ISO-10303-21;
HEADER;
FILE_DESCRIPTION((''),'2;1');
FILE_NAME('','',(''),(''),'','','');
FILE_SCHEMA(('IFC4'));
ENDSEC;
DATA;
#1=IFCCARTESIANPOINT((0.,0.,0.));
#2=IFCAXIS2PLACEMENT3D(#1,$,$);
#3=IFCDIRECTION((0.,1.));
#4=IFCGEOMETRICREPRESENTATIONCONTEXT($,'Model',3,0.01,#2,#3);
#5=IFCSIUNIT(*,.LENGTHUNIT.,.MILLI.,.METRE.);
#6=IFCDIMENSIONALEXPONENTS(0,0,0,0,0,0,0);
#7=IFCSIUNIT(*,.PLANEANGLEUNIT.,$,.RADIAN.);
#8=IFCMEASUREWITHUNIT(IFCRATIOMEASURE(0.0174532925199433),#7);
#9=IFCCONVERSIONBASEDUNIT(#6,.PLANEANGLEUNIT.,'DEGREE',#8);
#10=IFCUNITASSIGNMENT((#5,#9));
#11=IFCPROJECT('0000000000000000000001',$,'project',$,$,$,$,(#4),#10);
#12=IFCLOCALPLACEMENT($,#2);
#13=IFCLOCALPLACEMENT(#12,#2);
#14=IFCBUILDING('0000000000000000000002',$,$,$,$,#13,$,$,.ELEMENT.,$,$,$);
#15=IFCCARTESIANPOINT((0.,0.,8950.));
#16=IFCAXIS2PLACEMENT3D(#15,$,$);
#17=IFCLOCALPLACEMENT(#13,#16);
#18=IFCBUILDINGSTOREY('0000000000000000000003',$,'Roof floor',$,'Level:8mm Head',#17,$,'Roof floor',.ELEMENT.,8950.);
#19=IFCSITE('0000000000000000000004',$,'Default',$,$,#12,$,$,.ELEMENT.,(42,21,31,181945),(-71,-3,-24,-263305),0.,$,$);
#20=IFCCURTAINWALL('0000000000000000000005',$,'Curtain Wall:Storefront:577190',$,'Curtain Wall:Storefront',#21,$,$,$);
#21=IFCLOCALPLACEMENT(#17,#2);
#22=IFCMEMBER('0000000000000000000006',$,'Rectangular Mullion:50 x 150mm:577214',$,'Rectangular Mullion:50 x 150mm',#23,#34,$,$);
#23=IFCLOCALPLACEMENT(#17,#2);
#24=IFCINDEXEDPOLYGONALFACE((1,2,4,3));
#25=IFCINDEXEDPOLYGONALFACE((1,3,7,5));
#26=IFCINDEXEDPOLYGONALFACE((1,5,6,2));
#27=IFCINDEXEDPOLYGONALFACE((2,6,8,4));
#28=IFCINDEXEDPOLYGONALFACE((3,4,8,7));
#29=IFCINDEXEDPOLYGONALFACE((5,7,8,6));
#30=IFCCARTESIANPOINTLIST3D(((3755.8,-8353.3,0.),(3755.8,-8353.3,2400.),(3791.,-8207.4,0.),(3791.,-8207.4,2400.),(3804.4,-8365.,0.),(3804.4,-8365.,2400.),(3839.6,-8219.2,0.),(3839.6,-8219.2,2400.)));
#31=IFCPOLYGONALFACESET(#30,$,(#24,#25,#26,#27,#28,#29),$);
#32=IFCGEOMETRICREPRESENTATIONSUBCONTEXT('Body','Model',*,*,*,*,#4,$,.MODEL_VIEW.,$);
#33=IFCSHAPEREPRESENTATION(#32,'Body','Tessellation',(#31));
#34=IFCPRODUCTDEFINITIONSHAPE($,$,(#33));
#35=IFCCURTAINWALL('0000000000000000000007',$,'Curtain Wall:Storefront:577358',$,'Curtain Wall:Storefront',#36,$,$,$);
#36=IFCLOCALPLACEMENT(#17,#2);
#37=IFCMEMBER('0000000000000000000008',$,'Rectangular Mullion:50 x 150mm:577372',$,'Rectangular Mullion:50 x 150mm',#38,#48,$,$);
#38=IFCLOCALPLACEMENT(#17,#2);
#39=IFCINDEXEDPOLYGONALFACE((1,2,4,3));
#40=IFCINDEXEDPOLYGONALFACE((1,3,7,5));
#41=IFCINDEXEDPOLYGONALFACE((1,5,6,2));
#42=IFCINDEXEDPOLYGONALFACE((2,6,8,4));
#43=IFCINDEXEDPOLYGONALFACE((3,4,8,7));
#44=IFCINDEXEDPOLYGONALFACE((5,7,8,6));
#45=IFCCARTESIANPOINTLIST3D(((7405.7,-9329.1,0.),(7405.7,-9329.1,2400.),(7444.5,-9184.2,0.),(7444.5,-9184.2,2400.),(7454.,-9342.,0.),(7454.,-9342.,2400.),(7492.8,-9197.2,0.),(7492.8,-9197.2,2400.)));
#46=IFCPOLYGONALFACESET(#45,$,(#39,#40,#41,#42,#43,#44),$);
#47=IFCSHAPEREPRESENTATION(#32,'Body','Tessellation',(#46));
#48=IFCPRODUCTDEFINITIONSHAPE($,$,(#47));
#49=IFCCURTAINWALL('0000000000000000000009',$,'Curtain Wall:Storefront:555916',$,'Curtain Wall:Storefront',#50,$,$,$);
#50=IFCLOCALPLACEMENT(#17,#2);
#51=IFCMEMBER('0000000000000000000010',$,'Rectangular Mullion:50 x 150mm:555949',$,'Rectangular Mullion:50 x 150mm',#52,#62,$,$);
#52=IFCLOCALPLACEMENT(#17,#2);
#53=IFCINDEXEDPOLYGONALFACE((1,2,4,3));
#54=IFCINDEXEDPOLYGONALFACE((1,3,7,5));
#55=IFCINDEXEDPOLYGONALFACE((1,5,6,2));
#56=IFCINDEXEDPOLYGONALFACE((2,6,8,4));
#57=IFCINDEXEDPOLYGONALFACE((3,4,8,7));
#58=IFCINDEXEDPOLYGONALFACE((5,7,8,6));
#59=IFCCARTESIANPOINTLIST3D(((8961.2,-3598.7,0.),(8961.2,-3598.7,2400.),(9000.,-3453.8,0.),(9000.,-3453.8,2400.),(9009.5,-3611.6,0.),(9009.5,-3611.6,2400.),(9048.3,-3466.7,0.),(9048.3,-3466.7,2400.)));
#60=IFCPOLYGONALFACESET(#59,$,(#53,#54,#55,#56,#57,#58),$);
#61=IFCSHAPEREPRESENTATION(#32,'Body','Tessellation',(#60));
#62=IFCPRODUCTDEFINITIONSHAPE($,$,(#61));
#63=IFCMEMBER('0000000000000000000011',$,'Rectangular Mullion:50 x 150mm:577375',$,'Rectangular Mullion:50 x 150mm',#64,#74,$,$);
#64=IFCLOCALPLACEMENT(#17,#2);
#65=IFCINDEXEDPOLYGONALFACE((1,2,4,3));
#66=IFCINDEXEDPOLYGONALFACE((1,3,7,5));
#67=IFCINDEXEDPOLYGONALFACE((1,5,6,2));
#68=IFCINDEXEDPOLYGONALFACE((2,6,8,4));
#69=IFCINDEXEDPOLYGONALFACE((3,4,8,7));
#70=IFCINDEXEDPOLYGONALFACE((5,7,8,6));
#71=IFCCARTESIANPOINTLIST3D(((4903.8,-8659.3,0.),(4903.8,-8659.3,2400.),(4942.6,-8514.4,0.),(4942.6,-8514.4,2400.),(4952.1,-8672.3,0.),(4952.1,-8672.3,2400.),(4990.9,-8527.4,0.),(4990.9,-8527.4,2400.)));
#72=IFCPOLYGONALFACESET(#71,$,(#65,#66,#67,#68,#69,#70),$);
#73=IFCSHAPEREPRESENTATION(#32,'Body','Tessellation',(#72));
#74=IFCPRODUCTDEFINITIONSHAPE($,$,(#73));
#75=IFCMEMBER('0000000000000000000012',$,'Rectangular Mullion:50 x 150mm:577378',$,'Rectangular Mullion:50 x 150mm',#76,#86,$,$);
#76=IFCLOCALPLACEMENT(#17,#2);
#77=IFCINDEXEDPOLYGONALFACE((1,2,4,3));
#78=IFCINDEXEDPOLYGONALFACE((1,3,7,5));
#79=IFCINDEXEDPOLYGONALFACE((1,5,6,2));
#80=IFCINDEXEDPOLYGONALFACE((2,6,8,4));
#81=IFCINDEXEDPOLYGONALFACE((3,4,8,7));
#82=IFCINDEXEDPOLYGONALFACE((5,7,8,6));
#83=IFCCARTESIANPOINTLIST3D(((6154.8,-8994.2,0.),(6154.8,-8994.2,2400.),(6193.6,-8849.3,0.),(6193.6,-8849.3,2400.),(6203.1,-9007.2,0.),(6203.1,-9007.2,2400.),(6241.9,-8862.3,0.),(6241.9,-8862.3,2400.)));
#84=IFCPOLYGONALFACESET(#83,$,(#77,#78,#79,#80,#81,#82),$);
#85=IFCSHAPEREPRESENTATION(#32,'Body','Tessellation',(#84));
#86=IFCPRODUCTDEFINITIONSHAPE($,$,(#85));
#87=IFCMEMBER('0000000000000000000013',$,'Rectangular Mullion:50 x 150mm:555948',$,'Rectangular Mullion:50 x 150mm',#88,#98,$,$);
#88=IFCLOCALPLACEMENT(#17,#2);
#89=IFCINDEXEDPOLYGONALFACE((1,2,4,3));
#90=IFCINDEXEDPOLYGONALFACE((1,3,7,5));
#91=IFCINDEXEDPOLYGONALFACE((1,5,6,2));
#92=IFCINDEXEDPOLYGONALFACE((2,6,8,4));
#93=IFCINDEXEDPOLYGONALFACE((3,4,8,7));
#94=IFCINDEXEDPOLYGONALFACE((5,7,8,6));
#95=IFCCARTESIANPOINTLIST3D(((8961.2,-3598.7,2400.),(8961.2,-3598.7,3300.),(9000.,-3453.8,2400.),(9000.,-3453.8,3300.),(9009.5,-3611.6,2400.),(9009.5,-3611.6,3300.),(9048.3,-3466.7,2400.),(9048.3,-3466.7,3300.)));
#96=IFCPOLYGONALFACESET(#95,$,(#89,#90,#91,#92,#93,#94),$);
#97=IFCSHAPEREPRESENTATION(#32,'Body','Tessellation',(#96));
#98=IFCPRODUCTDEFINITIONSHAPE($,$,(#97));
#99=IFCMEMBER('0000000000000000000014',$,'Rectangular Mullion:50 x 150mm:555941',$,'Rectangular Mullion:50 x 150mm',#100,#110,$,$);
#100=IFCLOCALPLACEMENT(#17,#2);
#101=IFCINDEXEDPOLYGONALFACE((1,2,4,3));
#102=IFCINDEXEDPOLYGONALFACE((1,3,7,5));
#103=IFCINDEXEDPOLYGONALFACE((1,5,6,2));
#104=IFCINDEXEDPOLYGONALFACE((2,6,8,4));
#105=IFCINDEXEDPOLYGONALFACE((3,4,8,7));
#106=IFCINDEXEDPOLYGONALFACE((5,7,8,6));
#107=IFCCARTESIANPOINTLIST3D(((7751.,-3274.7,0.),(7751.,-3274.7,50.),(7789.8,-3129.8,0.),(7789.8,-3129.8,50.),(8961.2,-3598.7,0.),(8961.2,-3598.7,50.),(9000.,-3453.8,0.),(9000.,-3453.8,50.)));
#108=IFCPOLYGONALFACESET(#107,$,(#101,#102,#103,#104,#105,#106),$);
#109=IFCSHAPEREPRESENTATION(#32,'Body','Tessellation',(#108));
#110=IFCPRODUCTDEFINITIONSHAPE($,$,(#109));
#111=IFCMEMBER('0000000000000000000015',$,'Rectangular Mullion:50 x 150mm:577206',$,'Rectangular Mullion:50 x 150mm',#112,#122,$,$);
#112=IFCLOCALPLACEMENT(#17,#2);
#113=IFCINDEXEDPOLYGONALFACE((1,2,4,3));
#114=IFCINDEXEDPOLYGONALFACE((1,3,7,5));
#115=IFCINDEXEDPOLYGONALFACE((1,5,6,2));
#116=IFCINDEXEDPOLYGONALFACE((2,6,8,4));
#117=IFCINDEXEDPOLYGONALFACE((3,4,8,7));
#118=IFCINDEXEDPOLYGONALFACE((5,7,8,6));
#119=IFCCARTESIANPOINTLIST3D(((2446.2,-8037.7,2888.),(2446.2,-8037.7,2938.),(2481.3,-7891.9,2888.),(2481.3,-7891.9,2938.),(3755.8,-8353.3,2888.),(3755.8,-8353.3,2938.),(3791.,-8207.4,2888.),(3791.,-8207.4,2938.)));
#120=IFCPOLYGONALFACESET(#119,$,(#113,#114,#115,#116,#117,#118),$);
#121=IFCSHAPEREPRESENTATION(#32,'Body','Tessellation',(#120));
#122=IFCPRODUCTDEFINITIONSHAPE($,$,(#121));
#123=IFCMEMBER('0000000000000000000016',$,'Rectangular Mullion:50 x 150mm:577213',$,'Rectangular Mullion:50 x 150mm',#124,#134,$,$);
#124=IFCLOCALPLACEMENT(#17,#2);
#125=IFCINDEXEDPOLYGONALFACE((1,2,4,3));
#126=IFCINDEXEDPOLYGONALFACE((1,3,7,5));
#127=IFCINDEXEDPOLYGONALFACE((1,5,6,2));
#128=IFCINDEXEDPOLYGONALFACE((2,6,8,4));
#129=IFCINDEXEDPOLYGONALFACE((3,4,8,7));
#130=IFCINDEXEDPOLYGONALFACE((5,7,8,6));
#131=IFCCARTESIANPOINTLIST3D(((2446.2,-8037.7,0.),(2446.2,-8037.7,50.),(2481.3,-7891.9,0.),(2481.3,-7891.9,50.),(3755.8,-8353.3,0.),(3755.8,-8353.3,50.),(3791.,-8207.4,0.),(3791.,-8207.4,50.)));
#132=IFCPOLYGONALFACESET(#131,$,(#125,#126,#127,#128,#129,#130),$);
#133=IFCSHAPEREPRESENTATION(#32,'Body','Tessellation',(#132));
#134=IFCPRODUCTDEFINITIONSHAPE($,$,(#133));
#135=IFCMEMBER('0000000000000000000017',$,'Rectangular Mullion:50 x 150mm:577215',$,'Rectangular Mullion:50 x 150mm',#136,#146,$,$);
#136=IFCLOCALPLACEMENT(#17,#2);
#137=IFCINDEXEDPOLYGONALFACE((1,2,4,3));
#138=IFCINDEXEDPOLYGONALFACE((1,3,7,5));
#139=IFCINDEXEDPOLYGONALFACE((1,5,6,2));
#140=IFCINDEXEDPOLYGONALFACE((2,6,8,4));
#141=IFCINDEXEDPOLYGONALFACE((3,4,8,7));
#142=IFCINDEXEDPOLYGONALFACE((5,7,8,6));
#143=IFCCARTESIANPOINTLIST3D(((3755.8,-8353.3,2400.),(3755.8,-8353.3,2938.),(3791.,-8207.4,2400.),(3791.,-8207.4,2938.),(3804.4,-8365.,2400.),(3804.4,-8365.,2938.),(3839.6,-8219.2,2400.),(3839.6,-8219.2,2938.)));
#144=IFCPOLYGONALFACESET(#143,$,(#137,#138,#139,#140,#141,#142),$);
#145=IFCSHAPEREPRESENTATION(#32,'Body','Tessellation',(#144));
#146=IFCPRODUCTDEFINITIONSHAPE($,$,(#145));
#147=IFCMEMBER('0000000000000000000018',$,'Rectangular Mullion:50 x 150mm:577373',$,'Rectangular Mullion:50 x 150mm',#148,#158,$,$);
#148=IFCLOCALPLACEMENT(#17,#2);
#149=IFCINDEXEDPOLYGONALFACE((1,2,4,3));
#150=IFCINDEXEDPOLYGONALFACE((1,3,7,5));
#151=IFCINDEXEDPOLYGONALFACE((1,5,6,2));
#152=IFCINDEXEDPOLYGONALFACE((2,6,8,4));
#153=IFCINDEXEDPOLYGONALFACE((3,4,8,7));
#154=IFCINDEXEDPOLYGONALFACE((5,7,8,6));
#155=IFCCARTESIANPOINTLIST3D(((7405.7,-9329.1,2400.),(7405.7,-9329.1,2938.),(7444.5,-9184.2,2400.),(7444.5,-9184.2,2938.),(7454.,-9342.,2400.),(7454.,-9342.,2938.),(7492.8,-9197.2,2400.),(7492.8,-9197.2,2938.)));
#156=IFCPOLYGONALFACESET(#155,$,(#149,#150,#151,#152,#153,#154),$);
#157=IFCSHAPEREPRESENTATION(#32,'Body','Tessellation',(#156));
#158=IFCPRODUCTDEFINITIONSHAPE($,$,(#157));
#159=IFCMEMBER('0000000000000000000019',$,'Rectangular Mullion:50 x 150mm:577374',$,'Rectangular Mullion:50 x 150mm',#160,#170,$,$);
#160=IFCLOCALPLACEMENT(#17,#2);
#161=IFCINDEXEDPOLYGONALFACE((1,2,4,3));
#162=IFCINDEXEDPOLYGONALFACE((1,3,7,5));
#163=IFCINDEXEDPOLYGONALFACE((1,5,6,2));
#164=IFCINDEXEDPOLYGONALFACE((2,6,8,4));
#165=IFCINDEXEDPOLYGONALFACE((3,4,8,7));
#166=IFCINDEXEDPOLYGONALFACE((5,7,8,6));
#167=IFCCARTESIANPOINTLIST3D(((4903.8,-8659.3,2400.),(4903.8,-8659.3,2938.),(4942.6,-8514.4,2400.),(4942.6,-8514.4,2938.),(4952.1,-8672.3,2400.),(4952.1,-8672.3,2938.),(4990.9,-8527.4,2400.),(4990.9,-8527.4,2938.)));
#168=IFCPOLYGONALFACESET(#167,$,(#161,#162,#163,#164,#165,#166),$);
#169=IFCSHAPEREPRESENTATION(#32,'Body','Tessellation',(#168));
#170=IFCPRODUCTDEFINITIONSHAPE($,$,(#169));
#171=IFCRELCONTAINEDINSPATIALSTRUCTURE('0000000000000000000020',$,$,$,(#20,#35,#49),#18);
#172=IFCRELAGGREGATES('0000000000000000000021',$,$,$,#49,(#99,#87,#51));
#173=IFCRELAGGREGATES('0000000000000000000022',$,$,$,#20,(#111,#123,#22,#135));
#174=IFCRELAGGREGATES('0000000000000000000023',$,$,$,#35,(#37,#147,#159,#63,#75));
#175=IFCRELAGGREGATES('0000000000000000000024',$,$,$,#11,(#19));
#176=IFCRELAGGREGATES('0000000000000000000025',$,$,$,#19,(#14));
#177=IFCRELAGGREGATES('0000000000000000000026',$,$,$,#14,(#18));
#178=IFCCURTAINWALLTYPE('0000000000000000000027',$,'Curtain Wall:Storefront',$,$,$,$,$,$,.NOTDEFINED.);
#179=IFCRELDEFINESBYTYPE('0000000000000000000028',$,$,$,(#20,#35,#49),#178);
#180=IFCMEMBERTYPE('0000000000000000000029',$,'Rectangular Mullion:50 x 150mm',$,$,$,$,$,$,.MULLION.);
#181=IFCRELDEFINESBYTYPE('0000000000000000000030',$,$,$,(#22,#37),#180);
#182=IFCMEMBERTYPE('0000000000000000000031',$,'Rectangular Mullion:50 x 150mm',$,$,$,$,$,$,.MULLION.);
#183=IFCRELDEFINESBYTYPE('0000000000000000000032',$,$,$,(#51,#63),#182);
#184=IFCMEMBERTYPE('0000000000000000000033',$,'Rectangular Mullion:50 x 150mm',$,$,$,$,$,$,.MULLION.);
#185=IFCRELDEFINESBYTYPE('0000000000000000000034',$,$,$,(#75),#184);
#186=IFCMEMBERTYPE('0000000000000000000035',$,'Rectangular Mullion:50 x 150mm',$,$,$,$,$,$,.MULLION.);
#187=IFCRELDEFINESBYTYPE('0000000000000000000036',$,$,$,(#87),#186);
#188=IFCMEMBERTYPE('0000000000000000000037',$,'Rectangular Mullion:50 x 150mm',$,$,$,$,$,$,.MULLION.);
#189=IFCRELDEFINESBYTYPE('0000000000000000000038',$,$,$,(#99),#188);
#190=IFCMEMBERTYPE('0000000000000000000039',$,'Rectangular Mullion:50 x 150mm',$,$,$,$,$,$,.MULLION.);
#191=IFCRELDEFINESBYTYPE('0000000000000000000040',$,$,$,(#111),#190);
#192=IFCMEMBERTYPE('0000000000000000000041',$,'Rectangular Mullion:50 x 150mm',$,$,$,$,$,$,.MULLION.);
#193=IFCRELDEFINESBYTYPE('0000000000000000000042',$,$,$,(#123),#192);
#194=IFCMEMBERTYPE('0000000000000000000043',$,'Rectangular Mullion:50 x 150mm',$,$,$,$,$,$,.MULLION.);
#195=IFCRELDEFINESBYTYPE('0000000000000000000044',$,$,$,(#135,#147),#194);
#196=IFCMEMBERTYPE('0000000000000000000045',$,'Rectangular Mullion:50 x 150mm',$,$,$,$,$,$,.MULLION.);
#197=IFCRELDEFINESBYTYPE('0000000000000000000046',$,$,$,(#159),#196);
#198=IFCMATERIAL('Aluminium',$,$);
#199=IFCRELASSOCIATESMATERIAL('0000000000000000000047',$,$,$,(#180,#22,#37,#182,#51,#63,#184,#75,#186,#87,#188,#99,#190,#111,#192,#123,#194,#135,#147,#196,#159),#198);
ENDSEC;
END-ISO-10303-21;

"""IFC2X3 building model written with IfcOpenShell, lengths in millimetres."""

from ifc_helpers import new_model, entity, si_unit, converted_unit, direction, frame, origin, origin_2d_with_axis, place, context, subcontext, project, spatial, rectangle, extrude, source, transform, mapped, material, type_object, type_shapes, element, aggregate, save


model = new_model("IFC2X3")

# Units and contexts
model_context = context("Model", 3, precision=0.01, world=origin(), true_north=direction((0.0, 1.0)))
body_context = subcontext(model_context, "Body", "Model", "MODEL_VIEW")
ifc_project = project(units=[si_unit("LENGTHUNIT", "METRE", prefix="MILLI"), converted_unit("PLANEANGLEUNIT", "DEGREE", entity("IfcRatioMeasure", 0.0174532925199433), si_unit("PLANEANGLEUNIT", "RADIAN"), dimensions=[0, 0, 0, 0, 0, 0, 0])], contexts=[model_context])

# Site, building, storey
site_placement = place(None, origin())
site = spatial("IfcSite", under=ifc_project, at=site_placement, Name="Default", CompositionType="ELEMENT", RefLatitude=(42, 21, 31, 181945), RefLongitude=(-71, -3, -24, -263305), RefElevation=0.0)
building_placement = place(site_placement, origin())
building = spatial("IfcBuilding", under=site, at=building_placement, CompositionType="ELEMENT")
storey_placement = place(building_placement, frame((0.0, 0.0, 8950.0)))
storey = spatial("IfcBuildingStorey", under=building, at=storey_placement, Name="Roof floor", ObjectType="Level:8mm Head", LongName="Roof floor", CompositionType="ELEMENT", Elevation=8950.0)

# Curtain walls, members
curtain_wall_type = type_object("IfcCurtainWallType", Name="Curtain Wall:Storefront", PredefinedType="NOTDEFINED")
curtain_wall_1_placement = place(storey_placement, frame((0.0, 0.0, -8950.0)))
curtain_wall_1 = element("IfcCurtainWall", 1, at=curtain_wall_1_placement, inside=storey, type_object=curtain_wall_type, Name="Curtain Wall:Storefront:577190", ObjectType="Curtain Wall:Storefront")
ifc_material_1 = material(Name="Aluminium")
member_type_1 = type_object("IfcMemberType", Name="Rectangular Mullion:50 x 150mm", PredefinedType="MULLION", material=ifc_material_1)
shared_shape_1 = source(origin(), body_context, "Body", "SweptSolid", [
    extrude(rectangle(XDim=150.0, YDim=50.0, at=origin_2d_with_axis()), frame((-25.0, 0.0, -2400.0), z_axis=(0.0, 0.0, 1.0), x_axis=(0.0, -1.0, 0.0)), (0.0, 0.0, 1.0), 2400.0),
])
type_shapes(member_type_1, [shared_shape_1])
member_1_placement = place(storey_placement, frame((3822.0, -8292.1, 0.0), z_axis=(0.0, 0.0, -1.0), x_axis=(0.972184, -0.234217, 0.0)))
member_1 = element("IfcMember", 2, at=member_1_placement, type_object=member_type_1, material=ifc_material_1, Name="Rectangular Mullion:50 x 150mm:577214", ObjectType="Rectangular Mullion:50 x 150mm", context=body_context, shape_type="MappedRepresentation", body=[
    mapped(shared_shape_1, transform((0.0, 0.0, 0.0), scale=1.0)),
])
curtain_wall_2_placement = place(storey_placement, frame((0.0, 0.0, -8950.0)))
curtain_wall_2 = element("IfcCurtainWall", 3, at=curtain_wall_2_placement, inside=storey, type_object=curtain_wall_type, Name="Curtain Wall:Storefront:577358", ObjectType="Curtain Wall:Storefront")
member_2_placement = place(storey_placement, frame((7473.4, -9269.6, 0.0), z_axis=(0.0, 0.0, -1.0), x_axis=(0.965983, -0.258607, 0.0)))
member_2 = element("IfcMember", 4, at=member_2_placement, type_object=member_type_1, material=ifc_material_1, Name="Rectangular Mullion:50 x 150mm:577372", ObjectType="Rectangular Mullion:50 x 150mm", context=body_context, shape_type="MappedRepresentation", body=[
    mapped(shared_shape_1, transform((0.0, 0.0, 0.0), scale=1.0)),
])
curtain_wall_3_placement = place(storey_placement, frame((0.0, 0.0, -8950.0)))
curtain_wall_3 = element("IfcCurtainWall", 5, at=curtain_wall_3_placement, inside=storey, type_object=curtain_wall_type, Name="Curtain Wall:Storefront:555916", ObjectType="Curtain Wall:Storefront")
member_type_2 = type_object("IfcMemberType", Name="Rectangular Mullion:50 x 150mm", PredefinedType="MULLION", material=ifc_material_1)
shared_shape_2 = source(origin(), body_context, "Body", "SweptSolid", [
    extrude(rectangle(XDim=150.0, YDim=50.0, at=origin_2d_with_axis()), frame((-25.0, 0.0, -2400.0), z_axis=(0.0, 0.0, 1.0), x_axis=(0.0, -1.0, 0.0)), (0.0, 0.0, 1.0), 2400.0),
])
type_shapes(member_type_2, [shared_shape_2])
member_3_placement = place(storey_placement, frame((9028.9, -3539.2, 2400.0), z_axis=(0.0, 0.0, 1.0), x_axis=(0.965983, -0.258607, 0.0)))
member_3 = element("IfcMember", 6, at=member_3_placement, type_object=member_type_2, material=ifc_material_1, Name="Rectangular Mullion:50 x 150mm:555949", ObjectType="Rectangular Mullion:50 x 150mm", context=body_context, shape_type="MappedRepresentation", body=[
    mapped(shared_shape_2, transform((0.0, 0.0, 0.0), scale=1.0)),
])

# Members
member_4_placement = place(storey_placement, frame((4923.2, -8586.9, 2400.0), z_axis=(0.0, 0.0, 1.0), x_axis=(-0.965983, 0.258607, 0.0)))
member_4 = element("IfcMember", 7, at=member_4_placement, type_object=member_type_2, material=ifc_material_1, Name="Rectangular Mullion:50 x 150mm:577375", ObjectType="Rectangular Mullion:50 x 150mm", context=body_context, shape_type="MappedRepresentation", body=[
    mapped(shared_shape_2, transform((0.0, 0.0, 0.0), scale=1.0)),
])
member_type_3 = type_object("IfcMemberType", Name="Rectangular Mullion:50 x 150mm", PredefinedType="MULLION", material=ifc_material_1)
shared_shape_3 = source(origin(), body_context, "Body", "SweptSolid", [
    extrude(rectangle(XDim=150.0, YDim=50.0, at=origin_2d_with_axis()), frame((0.0, 0.0, -2400.0), z_axis=(0.0, 0.0, 1.0), x_axis=(0.0, -1.0, 0.0)), (0.0, 0.0, 1.0), 2400.0),
])
type_shapes(member_type_3, [shared_shape_3])
member_5_placement = place(storey_placement, frame((6198.3, -8928.2, 0.0), z_axis=(0.0, 0.0, -1.0), x_axis=(0.965983, -0.258607, 0.0)))
member_5 = element("IfcMember", 8, at=member_5_placement, type_object=member_type_3, material=ifc_material_1, Name="Rectangular Mullion:50 x 150mm:577378", ObjectType="Rectangular Mullion:50 x 150mm", context=body_context, shape_type="MappedRepresentation", body=[
    mapped(shared_shape_3, transform((0.0, 0.0, 0.0), scale=1.0)),
])
member_type_4 = type_object("IfcMemberType", Name="Rectangular Mullion:50 x 150mm", PredefinedType="MULLION", material=ifc_material_1)
shared_shape_4 = source(origin(), body_context, "Body", "SweptSolid", [
    extrude(rectangle(XDim=150.0, YDim=50.0, at=origin_2d_with_axis()), frame((-25.0, 0.0, -900.0), z_axis=(0.0, 0.0, 1.0), x_axis=(0.0, -1.0, 0.0)), (0.0, 0.0, 1.0), 900.0),
])
type_shapes(member_type_4, [shared_shape_4])
member_6_placement = place(storey_placement, frame((9028.9, -3539.2, 3300.0), z_axis=(0.0, 0.0, 1.0), x_axis=(0.965983, -0.258607, 0.0)))
member_6 = element("IfcMember", 9, at=member_6_placement, type_object=member_type_4, material=ifc_material_1, Name="Rectangular Mullion:50 x 150mm:555948", ObjectType="Rectangular Mullion:50 x 150mm", context=body_context, shape_type="MappedRepresentation", body=[
    mapped(shared_shape_4, transform((0.0, 0.0, 0.0), scale=1.0)),
])
member_type_5 = type_object("IfcMemberType", Name="Rectangular Mullion:50 x 150mm", PredefinedType="MULLION", material=ifc_material_1)
shared_shape_5 = source(origin(), body_context, "Body", "SweptSolid", [
    extrude(rectangle(XDim=150.0, YDim=50.0, at=origin_2d_with_axis()), frame((-25.0, 0.0, -1252.9), z_axis=(0.0, 0.0, 1.0), x_axis=(0.0, -1.0, 0.0)), (0.0, 0.0, 1.0), 1252.9),
])
type_shapes(member_type_5, [shared_shape_5])
member_7_placement = place(storey_placement, frame((8980.6, -3526.2, 0.0), z_axis=(0.965983, -0.258607, 0.0), x_axis=(0.0, 0.0, -1.0)))
member_7 = element("IfcMember", 10, at=member_7_placement, type_object=member_type_5, material=ifc_material_1, Name="Rectangular Mullion:50 x 150mm:555941", ObjectType="Rectangular Mullion:50 x 150mm", context=body_context, shape_type="MappedRepresentation", body=[
    mapped(shared_shape_5, transform((0.0, 0.0, 0.0), scale=1.0)),
])
member_type_6 = type_object("IfcMemberType", Name="Rectangular Mullion:50 x 150mm", PredefinedType="MULLION", material=ifc_material_1)
shared_shape_6 = source(origin(), body_context, "Body", "SweptSolid", [
    extrude(rectangle(XDim=150.0, YDim=50.0, at=origin_2d_with_axis()), frame((-25.0, 0.0, -1347.1), z_axis=(0.0, 0.0, 1.0), x_axis=(0.0, -1.0, 0.0)), (0.0, 0.0, 1.0), 1347.1),
])
type_shapes(member_type_6, [shared_shape_6])
member_8_placement = place(storey_placement, frame((3773.4, -8280.4, 2938.0), z_axis=(0.972184, -0.234217, 0.0), x_axis=(0.0, 0.0, 1.0)))
member_8 = element("IfcMember", 11, at=member_8_placement, type_object=member_type_6, material=ifc_material_1, Name="Rectangular Mullion:50 x 150mm:577206", ObjectType="Rectangular Mullion:50 x 150mm", context=body_context, shape_type="MappedRepresentation", body=[
    mapped(shared_shape_6, transform((0.0, 0.0, 0.0), scale=1.0)),
])
member_type_7 = type_object("IfcMemberType", Name="Rectangular Mullion:50 x 150mm", PredefinedType="MULLION", material=ifc_material_1)
shared_shape_7 = source(origin(), body_context, "Body", "SweptSolid", [
    extrude(rectangle(XDim=150.0, YDim=50.0, at=origin_2d_with_axis()), frame((-25.0, 0.0, -1347.1), z_axis=(0.0, 0.0, 1.0), x_axis=(0.0, -1.0, 0.0)), (0.0, 0.0, 1.0), 1347.1),
])
type_shapes(member_type_7, [shared_shape_7])
member_9_placement = place(storey_placement, frame((2463.7, -7964.8, 0.0), z_axis=(-0.972184, 0.234217, 0.0), x_axis=(0.0, 0.0, -1.0)))
member_9 = element("IfcMember", 12, at=member_9_placement, type_object=member_type_7, material=ifc_material_1, Name="Rectangular Mullion:50 x 150mm:577213", ObjectType="Rectangular Mullion:50 x 150mm", context=body_context, shape_type="MappedRepresentation", body=[
    mapped(shared_shape_7, transform((0.0, 0.0, 0.0), scale=1.0)),
])
member_type_8 = type_object("IfcMemberType", Name="Rectangular Mullion:50 x 150mm", PredefinedType="MULLION", material=ifc_material_1)
shared_shape_8 = source(origin(), body_context, "Body", "SweptSolid", [
    extrude(rectangle(XDim=150.0, YDim=50.0, at=origin_2d_with_axis()), frame((-25.0, 0.0, -538.0), z_axis=(0.0, 0.0, 1.0), x_axis=(0.0, -1.0, 0.0)), (0.0, 0.0, 1.0), 538.0),
])
type_shapes(member_type_8, [shared_shape_8])
member_10_placement = place(storey_placement, frame((3822.0, -8292.1, 2400.0), z_axis=(0.0, 0.0, -1.0), x_axis=(0.972184, -0.234217, 0.0)))
member_10 = element("IfcMember", 13, at=member_10_placement, type_object=member_type_8, material=ifc_material_1, Name="Rectangular Mullion:50 x 150mm:577215", ObjectType="Rectangular Mullion:50 x 150mm", context=body_context, shape_type="MappedRepresentation", body=[
    mapped(shared_shape_8, transform((0.0, 0.0, 0.0), scale=1.0)),
])
member_11_placement = place(storey_placement, frame((7473.4, -9269.6, 2400.0), z_axis=(0.0, 0.0, -1.0), x_axis=(0.965983, -0.258607, 0.0)))
member_11 = element("IfcMember", 14, at=member_11_placement, type_object=member_type_8, material=ifc_material_1, Name="Rectangular Mullion:50 x 150mm:577373", ObjectType="Rectangular Mullion:50 x 150mm", context=body_context, shape_type="MappedRepresentation", body=[
    mapped(shared_shape_8, transform((0.0, 0.0, 0.0), scale=1.0)),
])
member_type_9 = type_object("IfcMemberType", Name="Rectangular Mullion:50 x 150mm", PredefinedType="MULLION", material=ifc_material_1)
shared_shape_9 = source(origin(), body_context, "Body", "SweptSolid", [
    extrude(rectangle(XDim=150.0, YDim=50.0, at=origin_2d_with_axis()), frame((-25.0, 0.0, -538.0), z_axis=(0.0, 0.0, 1.0), x_axis=(0.0, -1.0, 0.0)), (0.0, 0.0, 1.0), 538.0),
])
type_shapes(member_type_9, [shared_shape_9])
member_12_placement = place(storey_placement, frame((4923.2, -8586.9, 2938.0), z_axis=(0.0, 0.0, 1.0), x_axis=(-0.965983, 0.258607, 0.0)))
member_12 = element("IfcMember", 15, at=member_12_placement, type_object=member_type_9, material=ifc_material_1, Name="Rectangular Mullion:50 x 150mm:577374", ObjectType="Rectangular Mullion:50 x 150mm", context=body_context, shape_type="MappedRepresentation", body=[
    mapped(shared_shape_9, transform((0.0, 0.0, 0.0), scale=1.0)),
])

aggregate(curtain_wall_3, [member_7, member_6, member_3])
aggregate(curtain_wall_1, [member_8, member_9, member_1, member_10])
aggregate(curtain_wall_2, [member_2, member_11, member_12, member_4, member_5])

save(model, "model.ifc")
